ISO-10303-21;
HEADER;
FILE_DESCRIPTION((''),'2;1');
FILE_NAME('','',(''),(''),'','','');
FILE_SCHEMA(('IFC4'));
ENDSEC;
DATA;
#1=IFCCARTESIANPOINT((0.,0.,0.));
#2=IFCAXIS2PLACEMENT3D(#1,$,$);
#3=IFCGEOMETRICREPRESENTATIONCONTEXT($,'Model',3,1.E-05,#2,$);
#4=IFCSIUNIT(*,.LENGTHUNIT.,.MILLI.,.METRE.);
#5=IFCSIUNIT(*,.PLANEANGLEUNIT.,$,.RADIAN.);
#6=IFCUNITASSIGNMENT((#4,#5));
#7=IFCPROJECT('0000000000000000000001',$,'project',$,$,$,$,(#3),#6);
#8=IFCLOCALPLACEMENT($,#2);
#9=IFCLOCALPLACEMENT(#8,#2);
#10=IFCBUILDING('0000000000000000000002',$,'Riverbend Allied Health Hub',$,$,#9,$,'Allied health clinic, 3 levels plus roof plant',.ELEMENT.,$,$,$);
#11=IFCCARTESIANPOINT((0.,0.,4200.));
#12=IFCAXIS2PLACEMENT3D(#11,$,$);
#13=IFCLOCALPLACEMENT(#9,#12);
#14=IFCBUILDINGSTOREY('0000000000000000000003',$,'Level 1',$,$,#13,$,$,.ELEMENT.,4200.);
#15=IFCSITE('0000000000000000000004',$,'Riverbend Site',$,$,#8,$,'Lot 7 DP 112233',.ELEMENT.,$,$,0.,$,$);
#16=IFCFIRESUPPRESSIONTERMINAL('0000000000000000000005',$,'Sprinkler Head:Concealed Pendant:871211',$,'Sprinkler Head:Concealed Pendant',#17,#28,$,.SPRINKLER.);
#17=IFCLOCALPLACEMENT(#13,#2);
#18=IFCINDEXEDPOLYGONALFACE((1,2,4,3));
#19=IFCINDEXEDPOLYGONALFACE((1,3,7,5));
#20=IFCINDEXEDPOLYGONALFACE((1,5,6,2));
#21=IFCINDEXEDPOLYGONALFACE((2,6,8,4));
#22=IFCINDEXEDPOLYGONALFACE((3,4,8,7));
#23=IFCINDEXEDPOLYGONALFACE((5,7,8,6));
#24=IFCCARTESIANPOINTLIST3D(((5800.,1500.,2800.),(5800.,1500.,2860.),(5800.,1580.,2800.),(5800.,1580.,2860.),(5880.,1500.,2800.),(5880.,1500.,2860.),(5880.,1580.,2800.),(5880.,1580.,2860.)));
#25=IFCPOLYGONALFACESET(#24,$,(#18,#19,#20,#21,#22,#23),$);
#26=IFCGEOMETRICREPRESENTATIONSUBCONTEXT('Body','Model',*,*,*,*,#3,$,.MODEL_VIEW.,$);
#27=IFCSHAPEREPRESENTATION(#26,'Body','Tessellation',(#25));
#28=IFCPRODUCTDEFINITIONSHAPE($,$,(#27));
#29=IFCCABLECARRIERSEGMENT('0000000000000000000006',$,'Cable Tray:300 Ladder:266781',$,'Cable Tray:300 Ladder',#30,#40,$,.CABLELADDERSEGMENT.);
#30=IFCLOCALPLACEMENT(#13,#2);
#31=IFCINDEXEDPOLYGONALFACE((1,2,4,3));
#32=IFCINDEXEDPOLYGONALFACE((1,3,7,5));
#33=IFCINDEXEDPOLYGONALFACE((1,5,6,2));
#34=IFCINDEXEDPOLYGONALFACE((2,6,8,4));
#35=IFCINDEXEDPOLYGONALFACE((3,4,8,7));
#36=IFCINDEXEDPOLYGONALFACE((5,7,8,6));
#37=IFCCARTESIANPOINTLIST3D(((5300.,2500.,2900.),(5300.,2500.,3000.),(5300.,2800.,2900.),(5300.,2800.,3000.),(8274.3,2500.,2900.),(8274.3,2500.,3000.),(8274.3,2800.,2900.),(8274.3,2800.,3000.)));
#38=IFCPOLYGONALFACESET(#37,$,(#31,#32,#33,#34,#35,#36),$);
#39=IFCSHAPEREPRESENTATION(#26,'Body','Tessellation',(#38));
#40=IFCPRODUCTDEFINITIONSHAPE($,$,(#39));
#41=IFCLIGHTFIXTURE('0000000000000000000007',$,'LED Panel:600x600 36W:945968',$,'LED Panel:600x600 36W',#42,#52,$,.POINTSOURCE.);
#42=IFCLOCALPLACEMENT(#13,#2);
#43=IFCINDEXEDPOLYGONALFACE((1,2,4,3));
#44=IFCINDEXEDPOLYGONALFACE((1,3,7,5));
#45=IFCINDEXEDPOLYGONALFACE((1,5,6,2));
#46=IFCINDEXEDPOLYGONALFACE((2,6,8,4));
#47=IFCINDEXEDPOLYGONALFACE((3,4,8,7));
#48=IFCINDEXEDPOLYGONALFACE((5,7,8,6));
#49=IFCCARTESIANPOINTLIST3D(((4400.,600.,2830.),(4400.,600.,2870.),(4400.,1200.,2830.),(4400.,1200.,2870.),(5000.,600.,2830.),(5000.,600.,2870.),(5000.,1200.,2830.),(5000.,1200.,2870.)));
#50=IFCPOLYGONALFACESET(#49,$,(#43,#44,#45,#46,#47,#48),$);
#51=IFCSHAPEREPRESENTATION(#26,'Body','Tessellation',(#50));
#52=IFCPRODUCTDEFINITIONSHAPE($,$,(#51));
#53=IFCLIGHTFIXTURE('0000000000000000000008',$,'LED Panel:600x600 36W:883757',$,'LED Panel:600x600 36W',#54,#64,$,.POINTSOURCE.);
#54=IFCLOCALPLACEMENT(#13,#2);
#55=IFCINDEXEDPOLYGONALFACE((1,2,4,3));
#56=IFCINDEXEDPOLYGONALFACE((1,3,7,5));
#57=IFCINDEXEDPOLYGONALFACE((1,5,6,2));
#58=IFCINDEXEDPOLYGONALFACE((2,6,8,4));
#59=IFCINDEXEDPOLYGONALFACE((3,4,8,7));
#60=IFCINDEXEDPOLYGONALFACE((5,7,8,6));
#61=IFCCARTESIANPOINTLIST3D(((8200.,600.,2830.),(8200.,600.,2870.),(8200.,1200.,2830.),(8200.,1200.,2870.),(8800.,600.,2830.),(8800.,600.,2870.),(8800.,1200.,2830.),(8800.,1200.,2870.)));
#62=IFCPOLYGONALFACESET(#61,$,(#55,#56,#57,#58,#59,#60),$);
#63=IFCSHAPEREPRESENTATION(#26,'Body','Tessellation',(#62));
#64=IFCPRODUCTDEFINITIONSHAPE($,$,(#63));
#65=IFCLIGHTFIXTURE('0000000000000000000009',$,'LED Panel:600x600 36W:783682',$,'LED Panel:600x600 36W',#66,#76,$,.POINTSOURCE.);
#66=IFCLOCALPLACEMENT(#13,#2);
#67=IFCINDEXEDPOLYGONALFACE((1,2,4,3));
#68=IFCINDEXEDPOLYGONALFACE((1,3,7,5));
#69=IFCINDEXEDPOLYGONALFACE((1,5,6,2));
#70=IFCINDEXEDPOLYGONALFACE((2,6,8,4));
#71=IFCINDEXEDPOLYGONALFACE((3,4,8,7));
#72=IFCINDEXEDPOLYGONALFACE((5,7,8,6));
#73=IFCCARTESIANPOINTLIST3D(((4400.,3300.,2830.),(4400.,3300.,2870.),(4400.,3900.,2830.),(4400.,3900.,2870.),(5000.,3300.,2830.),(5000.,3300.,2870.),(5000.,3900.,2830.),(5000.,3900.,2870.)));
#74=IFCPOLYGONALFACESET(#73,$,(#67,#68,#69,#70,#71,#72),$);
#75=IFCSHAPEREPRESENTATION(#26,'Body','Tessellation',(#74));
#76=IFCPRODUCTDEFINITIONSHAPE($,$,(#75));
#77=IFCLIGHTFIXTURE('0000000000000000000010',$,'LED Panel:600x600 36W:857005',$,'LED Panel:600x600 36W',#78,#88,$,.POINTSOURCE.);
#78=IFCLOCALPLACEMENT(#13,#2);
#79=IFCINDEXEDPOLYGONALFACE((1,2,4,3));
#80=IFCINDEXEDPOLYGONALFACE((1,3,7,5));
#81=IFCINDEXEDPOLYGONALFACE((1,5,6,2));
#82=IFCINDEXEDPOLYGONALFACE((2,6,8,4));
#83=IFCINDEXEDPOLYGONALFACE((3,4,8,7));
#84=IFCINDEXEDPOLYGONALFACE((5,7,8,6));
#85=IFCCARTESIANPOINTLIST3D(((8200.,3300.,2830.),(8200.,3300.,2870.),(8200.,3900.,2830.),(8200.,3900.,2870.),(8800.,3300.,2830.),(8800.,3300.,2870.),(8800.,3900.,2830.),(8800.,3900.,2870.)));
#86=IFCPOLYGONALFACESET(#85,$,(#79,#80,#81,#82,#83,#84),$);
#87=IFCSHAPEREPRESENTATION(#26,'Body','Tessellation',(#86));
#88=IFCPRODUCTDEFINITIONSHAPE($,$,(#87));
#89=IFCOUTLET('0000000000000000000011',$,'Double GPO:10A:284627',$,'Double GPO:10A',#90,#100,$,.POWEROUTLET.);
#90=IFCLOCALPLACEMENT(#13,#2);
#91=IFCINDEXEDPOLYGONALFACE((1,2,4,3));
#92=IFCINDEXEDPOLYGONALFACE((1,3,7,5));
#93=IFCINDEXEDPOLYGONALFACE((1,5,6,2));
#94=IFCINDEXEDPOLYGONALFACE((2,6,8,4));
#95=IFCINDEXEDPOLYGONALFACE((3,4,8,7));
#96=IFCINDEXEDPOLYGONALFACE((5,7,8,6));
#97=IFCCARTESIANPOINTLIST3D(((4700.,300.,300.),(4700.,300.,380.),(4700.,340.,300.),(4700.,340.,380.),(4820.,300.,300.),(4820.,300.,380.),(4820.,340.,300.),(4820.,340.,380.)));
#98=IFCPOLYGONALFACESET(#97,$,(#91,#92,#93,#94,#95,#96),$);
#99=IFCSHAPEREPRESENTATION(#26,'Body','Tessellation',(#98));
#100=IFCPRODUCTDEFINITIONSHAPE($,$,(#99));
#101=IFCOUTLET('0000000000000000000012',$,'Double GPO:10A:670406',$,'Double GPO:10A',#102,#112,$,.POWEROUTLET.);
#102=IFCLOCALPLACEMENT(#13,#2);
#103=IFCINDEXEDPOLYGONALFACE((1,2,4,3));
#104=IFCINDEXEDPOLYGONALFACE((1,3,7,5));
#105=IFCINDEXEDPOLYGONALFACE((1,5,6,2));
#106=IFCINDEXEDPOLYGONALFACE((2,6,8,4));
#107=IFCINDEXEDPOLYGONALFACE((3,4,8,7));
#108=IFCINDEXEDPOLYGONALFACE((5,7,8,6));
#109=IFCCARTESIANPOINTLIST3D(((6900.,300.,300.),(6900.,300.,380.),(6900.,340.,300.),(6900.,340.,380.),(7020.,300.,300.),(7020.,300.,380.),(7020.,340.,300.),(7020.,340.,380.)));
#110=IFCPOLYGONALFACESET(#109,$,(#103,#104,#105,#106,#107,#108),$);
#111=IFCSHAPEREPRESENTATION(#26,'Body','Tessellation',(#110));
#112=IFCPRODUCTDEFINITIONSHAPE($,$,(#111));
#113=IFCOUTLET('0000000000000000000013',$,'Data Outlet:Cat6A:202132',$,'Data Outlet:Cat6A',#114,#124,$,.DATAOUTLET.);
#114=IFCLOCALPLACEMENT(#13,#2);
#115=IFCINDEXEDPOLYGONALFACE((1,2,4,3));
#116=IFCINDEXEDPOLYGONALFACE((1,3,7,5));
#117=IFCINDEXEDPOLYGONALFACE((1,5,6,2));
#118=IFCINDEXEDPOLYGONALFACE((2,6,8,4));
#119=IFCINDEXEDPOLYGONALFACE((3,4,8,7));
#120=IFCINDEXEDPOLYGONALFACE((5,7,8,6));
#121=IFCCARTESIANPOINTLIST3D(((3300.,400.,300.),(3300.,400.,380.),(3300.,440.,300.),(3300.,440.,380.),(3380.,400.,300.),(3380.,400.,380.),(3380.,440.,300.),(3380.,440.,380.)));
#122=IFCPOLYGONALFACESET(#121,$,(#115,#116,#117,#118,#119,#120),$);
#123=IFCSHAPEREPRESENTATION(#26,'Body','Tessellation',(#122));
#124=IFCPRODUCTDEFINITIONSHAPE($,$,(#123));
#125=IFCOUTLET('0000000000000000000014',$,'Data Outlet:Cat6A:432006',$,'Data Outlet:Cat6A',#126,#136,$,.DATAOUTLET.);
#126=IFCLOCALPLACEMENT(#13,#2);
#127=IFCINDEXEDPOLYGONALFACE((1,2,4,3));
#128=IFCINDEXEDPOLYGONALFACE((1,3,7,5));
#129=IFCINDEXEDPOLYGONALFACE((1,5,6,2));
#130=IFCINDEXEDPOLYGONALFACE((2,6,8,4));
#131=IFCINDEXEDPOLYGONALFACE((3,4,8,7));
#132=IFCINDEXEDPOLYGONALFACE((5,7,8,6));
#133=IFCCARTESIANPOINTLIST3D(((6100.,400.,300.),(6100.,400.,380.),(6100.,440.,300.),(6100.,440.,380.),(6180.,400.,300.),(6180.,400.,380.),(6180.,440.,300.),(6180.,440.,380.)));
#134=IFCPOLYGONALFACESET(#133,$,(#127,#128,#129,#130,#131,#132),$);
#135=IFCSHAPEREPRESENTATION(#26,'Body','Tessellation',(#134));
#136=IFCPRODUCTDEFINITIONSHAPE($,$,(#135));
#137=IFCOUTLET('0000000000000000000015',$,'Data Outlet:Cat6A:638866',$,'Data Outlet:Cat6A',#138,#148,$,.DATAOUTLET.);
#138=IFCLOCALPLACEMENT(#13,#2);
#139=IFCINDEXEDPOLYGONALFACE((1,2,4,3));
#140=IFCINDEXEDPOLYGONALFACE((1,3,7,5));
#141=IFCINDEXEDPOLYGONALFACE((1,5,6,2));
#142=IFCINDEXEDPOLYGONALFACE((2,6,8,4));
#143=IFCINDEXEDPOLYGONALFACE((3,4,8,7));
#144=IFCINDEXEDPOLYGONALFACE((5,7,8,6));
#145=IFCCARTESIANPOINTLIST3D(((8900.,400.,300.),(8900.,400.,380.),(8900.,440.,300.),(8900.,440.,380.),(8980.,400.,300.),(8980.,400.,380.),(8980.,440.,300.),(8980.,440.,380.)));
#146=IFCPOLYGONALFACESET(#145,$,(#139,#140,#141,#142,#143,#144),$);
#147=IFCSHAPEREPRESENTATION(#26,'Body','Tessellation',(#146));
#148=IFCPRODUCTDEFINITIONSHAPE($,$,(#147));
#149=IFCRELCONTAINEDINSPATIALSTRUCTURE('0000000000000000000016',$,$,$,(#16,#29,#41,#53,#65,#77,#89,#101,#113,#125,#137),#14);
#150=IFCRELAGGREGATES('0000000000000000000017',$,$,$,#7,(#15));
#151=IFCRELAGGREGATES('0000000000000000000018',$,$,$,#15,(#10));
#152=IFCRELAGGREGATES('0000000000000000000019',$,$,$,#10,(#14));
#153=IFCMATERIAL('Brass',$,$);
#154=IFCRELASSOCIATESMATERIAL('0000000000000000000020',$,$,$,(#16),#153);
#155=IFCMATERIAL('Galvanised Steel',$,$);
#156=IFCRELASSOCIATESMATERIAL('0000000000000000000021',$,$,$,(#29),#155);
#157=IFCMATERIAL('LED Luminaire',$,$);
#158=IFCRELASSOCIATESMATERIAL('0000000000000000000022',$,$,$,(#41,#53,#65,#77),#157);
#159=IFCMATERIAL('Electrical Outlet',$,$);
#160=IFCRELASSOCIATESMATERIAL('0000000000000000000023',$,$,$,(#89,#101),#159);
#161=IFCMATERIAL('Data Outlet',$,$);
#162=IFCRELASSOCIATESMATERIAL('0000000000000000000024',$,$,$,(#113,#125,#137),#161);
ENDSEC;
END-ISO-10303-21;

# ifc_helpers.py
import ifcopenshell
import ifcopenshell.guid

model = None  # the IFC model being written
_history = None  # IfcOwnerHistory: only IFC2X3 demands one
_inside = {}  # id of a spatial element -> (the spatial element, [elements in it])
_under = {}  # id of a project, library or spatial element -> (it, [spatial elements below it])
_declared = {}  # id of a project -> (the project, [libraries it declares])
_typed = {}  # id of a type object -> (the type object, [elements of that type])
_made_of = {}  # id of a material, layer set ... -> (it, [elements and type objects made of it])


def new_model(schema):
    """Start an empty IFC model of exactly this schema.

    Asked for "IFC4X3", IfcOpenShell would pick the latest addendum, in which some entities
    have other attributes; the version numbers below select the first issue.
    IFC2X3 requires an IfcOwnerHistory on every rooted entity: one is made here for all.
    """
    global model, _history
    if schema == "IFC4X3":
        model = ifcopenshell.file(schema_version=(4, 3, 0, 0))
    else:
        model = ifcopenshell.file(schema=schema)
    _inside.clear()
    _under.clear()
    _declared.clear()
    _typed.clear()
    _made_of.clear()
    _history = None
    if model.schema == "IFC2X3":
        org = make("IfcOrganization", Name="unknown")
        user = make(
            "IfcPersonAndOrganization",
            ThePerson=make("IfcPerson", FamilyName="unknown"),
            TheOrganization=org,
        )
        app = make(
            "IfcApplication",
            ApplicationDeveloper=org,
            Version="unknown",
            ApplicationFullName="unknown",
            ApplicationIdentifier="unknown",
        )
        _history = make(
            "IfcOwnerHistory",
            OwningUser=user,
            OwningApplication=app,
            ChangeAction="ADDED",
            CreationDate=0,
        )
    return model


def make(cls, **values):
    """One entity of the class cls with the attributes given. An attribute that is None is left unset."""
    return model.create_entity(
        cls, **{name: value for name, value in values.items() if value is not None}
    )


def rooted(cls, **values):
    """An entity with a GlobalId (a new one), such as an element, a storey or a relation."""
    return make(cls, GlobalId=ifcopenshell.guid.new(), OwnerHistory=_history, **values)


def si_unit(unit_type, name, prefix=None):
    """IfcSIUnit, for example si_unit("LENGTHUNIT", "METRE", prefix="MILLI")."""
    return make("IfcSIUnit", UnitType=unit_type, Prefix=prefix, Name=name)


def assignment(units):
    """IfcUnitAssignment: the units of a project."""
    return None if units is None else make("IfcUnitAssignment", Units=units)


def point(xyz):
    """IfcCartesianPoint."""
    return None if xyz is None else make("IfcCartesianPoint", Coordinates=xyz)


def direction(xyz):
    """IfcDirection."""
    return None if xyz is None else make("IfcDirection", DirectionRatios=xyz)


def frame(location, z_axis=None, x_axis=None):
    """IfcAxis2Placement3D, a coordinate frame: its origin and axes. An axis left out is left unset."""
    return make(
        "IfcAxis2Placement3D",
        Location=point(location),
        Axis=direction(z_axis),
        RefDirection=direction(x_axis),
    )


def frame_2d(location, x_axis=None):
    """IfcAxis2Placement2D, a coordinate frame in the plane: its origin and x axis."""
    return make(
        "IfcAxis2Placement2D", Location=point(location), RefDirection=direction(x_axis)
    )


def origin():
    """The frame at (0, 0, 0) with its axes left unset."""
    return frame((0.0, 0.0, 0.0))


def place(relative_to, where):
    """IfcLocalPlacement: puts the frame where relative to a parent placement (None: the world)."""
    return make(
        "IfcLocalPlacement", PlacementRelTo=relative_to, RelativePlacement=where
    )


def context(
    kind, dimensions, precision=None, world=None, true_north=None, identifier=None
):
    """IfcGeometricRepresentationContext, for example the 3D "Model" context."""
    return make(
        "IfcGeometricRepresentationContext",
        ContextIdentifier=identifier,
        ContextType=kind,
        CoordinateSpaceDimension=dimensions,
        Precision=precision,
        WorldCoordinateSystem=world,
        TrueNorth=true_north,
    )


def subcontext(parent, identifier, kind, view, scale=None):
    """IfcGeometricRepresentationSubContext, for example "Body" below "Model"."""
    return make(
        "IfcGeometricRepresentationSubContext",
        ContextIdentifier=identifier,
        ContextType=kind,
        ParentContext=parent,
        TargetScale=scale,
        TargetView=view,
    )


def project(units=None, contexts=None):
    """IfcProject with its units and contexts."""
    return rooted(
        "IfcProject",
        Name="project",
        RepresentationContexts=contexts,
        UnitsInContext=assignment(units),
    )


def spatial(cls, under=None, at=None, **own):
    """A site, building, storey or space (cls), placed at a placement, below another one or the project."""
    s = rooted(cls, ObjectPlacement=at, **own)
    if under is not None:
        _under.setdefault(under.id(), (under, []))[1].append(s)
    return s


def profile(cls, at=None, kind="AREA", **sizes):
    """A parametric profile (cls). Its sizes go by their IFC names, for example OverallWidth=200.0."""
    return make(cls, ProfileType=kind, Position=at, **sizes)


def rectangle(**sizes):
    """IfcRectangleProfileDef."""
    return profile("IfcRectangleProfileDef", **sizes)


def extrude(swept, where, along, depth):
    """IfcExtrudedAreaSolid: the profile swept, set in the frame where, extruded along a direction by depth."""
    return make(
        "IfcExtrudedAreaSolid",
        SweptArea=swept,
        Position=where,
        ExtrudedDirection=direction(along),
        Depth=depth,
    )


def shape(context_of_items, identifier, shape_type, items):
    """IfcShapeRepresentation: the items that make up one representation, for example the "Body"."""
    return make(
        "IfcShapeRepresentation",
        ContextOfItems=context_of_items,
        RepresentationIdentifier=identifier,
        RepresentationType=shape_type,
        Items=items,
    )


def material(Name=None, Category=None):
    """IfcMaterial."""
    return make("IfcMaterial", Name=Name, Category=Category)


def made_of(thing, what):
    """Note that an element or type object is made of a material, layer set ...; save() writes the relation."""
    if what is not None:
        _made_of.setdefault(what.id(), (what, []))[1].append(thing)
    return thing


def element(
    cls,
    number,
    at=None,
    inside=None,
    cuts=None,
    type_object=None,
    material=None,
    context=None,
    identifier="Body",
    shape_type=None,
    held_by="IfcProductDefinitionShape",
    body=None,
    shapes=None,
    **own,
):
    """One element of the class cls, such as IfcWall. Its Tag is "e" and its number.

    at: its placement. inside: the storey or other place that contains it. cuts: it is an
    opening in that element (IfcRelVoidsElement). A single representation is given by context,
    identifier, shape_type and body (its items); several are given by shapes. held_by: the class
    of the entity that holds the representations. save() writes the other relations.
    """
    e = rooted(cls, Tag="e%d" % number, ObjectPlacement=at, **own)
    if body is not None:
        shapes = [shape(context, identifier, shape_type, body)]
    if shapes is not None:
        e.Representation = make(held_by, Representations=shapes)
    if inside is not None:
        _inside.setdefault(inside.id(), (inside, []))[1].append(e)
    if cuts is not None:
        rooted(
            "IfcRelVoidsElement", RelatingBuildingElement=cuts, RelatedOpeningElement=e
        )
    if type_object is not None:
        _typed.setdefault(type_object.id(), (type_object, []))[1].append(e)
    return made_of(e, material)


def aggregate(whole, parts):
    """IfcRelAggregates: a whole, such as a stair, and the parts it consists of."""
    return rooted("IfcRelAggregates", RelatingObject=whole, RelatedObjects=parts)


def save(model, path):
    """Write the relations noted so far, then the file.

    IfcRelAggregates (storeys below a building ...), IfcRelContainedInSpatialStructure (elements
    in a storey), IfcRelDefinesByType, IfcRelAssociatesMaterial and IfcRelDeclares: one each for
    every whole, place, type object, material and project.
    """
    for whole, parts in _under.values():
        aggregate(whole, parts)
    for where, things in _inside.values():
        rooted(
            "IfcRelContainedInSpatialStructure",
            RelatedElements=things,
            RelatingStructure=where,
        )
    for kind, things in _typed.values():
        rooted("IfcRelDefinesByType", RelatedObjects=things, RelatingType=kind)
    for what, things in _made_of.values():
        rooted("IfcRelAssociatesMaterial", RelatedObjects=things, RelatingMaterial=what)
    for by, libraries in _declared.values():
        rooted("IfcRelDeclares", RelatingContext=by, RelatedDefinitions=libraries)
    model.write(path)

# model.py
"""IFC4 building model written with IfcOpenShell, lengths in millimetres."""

from ifc_helpers import new_model, si_unit, frame, frame_2d, origin, place, context, subcontext, project, spatial, rectangle, extrude, material, element, save


model = new_model("IFC4")

# Units and contexts
model_context = context("Model", 3, precision=1e-05, world=origin())
body_context = subcontext(model_context, "Body", "Model", "MODEL_VIEW")
ifc_project = project(units=[si_unit("LENGTHUNIT", "METRE", prefix="MILLI"), si_unit("PLANEANGLEUNIT", "RADIAN")], contexts=[model_context])

# Site, building, storey
site_placement = place(None, origin())
site = spatial("IfcSite", under=ifc_project, at=site_placement, Name="Riverbend Site", LongName="Lot 7 DP 112233", CompositionType="ELEMENT", RefElevation=0.0)
building_placement = place(site_placement, origin())
building = spatial("IfcBuilding", under=site, at=building_placement, Name="Riverbend Allied Health Hub", LongName="Allied health clinic, 3 levels plus roof plant", CompositionType="ELEMENT")
storey_placement = place(building_placement, frame((0.0, 0.0, 4200.0)))
storey = spatial("IfcBuildingStorey", under=building, at=storey_placement, Name="Level 1", CompositionType="ELEMENT", Elevation=4200.0)

# Shared definitions
ifc_material_1 = material(Name="Galvanised Steel")

# Fire suppression terminal
ifc_material_2 = material(Name="Brass")
fire_suppression_terminal_placement = place(storey_placement, frame((5800.0, 1500.0, 2800.0)))
element("IfcFireSuppressionTerminal", 1, at=fire_suppression_terminal_placement, inside=storey, material=ifc_material_2, Name="Sprinkler Head:Concealed Pendant:871211", ObjectType="Sprinkler Head:Concealed Pendant", PredefinedType="SPRINKLER", context=body_context, shape_type="SweptSolid", body=[
    extrude(rectangle(XDim=80.0, YDim=80.0, at=frame_2d((40.0, 40.0))), origin(), (0.0, 0.0, 1.0), 60.0),
])

# Cable carrier segment
cable_carrier_segment_placement = place(storey_placement, frame((5300.0, 2500.0, 2900.0)))
element("IfcCableCarrierSegment", 2, at=cable_carrier_segment_placement, inside=storey, material=ifc_material_1, Name="Cable Tray:300 Ladder:266781", ObjectType="Cable Tray:300 Ladder", PredefinedType="CABLELADDERSEGMENT", context=body_context, shape_type="SweptSolid", body=[
    extrude(rectangle(XDim=2974.3, YDim=300.0, at=frame_2d((1487.1, 150.0))), origin(), (0.0, 0.0, 1.0), 100.0),
])

# Light fixtures
ifc_material_3 = material(Name="LED Luminaire")
for number, where, name in (
    (3, (4400.0, 600.0, 2830.0), "LED Panel:600x600 36W:945968"),
    (4, (8200.0, 600.0, 2830.0), "LED Panel:600x600 36W:883757"),
    (5, (4400.0, 3300.0, 2830.0), "LED Panel:600x600 36W:783682"),
    (6, (8200.0, 3300.0, 2830.0), "LED Panel:600x600 36W:857005"),
):
    element("IfcLightFixture", number, at=place(storey_placement, frame(where)), inside=storey, material=ifc_material_3, Name=name, ObjectType="LED Panel:600x600 36W", PredefinedType="POINTSOURCE", context=body_context, shape_type="SweptSolid", body=[
        extrude(rectangle(XDim=600.0, YDim=600.0, at=frame_2d((300.0, 300.0))), origin(), (0.0, 0.0, 1.0), 40.0),
    ])

# Outlets
ifc_material_4 = material(Name="Electrical Outlet")
for number, where, name in (
    (7, (4700.0, 300.0, 300.0), "Double GPO:10A:284627"),
    (8, (6900.0, 300.0, 300.0), "Double GPO:10A:670406"),
):
    element("IfcOutlet", number, at=place(storey_placement, frame(where)), inside=storey, material=ifc_material_4, Name=name, ObjectType="Double GPO:10A", PredefinedType="POWEROUTLET", context=body_context, shape_type="SweptSolid", body=[
        extrude(rectangle(XDim=120.0, YDim=40.0, at=frame_2d((60.0, 20.0))), origin(), (0.0, 0.0, 1.0), 80.0),
    ])
ifc_material_5 = material(Name="Data Outlet")
for number, where, name in (
    (9, (3300.0, 400.0, 300.0), "Data Outlet:Cat6A:202132"),
    (10, (6100.0, 400.0, 300.0), "Data Outlet:Cat6A:432006"),
    (11, (8900.0, 400.0, 300.0), "Data Outlet:Cat6A:638866"),
):
    element("IfcOutlet", number, at=place(storey_placement, frame(where)), inside=storey, material=ifc_material_5, Name=name, ObjectType="Data Outlet:Cat6A", PredefinedType="DATAOUTLET", context=body_context, shape_type="SweptSolid", body=[
        extrude(rectangle(XDim=80.0, YDim=40.0, at=frame_2d((40.0, 20.0))), origin(), (0.0, 0.0, 1.0), 80.0),
    ])

save(model, "model.ifc")
